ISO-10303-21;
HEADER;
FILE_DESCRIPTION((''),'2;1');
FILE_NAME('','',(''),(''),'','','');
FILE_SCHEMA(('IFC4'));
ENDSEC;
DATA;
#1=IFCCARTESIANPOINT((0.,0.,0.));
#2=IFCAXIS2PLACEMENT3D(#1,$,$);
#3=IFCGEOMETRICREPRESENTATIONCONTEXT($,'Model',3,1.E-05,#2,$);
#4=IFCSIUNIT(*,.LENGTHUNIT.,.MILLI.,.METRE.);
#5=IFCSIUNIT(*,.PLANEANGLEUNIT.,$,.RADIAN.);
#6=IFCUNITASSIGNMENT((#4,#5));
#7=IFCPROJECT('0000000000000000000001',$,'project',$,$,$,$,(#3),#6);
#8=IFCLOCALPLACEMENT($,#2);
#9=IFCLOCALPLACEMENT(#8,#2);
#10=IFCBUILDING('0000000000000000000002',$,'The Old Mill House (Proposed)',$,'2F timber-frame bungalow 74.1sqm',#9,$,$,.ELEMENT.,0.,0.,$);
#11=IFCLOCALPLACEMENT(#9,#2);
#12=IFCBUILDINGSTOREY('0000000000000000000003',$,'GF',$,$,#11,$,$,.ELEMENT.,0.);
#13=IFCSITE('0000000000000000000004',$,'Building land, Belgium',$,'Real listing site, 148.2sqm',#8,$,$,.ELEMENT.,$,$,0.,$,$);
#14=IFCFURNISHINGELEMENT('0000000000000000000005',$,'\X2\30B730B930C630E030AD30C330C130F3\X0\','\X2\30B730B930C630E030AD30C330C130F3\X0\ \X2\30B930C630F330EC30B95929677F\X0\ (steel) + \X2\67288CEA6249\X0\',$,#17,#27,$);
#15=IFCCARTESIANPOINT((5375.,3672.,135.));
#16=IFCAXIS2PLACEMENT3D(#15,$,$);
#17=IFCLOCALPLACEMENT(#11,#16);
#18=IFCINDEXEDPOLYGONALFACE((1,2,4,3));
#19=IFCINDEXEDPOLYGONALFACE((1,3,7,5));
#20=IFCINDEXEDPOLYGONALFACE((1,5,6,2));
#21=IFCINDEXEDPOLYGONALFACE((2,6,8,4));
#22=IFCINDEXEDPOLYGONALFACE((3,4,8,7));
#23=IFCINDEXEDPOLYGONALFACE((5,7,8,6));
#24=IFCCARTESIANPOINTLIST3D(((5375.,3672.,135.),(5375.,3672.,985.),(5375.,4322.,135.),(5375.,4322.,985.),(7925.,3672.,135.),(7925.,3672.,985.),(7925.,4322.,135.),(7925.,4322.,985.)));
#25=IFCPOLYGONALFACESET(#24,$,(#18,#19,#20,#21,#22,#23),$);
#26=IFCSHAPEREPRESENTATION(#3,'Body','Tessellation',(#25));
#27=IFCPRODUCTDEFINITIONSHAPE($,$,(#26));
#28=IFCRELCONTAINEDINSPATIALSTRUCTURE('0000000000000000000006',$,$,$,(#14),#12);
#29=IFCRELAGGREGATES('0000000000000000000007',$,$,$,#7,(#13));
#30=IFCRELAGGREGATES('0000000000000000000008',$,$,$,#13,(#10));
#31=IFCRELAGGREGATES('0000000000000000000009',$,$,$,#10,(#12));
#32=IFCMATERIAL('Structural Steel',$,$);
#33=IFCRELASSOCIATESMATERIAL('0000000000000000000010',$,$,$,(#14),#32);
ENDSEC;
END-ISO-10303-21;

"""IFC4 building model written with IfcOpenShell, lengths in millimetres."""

from ifc_helpers import new_model, si_unit, frame, frame_2d, origin, place, context, project, spatial, rectangle, extrude, material, element, save


model = new_model("IFC4")

# Units and contexts
model_context = context("Model", 3, precision=1e-05, world=origin())
ifc_project = project(units=[si_unit("LENGTHUNIT", "METRE", prefix="MILLI"), si_unit("PLANEANGLEUNIT", "RADIAN")], contexts=[model_context])

# Site, building, storey
site_placement = place(None, origin())
site = spatial("IfcSite", under=ifc_project, at=site_placement, Name="Building land, Belgium", ObjectType="Real listing site, 148.2sqm", CompositionType="ELEMENT", RefElevation=0.0)
building_placement = place(site_placement, origin())
building = spatial("IfcBuilding", under=site, at=building_placement, Name="The Old Mill House (Proposed)", ObjectType="2F timber-frame bungalow 74.1sqm", CompositionType="ELEMENT", ElevationOfRefHeight=0.0, ElevationOfTerrain=0.0)
storey_placement = place(building_placement, origin())
storey = spatial("IfcBuildingStorey", under=building, at=storey_placement, Name="GF", CompositionType="ELEMENT", Elevation=0.0)

# Furnishing element
ifc_material_1 = material(Name="Structural Steel")
furnishing_1_placement = place(storey_placement, frame((5375.0, 3672.0, 135.0)))
element("IfcFurnishingElement", 1, at=furnishing_1_placement, inside=storey, material=ifc_material_1, Name="システムキッチン", Description="システムキッチン ステンレス天板 (steel) + 木質扉", context=model_context, shape_type="SweptSolid", body=[
    extrude(rectangle(XDim=2550.0, YDim=650.0, at=frame_2d((1275.0, 325.0))), frame((5375.0, 3672.0, 135.0)), (0.0, 0.0, 1.0), 850.0),
])

save(model, "model.ifc")
